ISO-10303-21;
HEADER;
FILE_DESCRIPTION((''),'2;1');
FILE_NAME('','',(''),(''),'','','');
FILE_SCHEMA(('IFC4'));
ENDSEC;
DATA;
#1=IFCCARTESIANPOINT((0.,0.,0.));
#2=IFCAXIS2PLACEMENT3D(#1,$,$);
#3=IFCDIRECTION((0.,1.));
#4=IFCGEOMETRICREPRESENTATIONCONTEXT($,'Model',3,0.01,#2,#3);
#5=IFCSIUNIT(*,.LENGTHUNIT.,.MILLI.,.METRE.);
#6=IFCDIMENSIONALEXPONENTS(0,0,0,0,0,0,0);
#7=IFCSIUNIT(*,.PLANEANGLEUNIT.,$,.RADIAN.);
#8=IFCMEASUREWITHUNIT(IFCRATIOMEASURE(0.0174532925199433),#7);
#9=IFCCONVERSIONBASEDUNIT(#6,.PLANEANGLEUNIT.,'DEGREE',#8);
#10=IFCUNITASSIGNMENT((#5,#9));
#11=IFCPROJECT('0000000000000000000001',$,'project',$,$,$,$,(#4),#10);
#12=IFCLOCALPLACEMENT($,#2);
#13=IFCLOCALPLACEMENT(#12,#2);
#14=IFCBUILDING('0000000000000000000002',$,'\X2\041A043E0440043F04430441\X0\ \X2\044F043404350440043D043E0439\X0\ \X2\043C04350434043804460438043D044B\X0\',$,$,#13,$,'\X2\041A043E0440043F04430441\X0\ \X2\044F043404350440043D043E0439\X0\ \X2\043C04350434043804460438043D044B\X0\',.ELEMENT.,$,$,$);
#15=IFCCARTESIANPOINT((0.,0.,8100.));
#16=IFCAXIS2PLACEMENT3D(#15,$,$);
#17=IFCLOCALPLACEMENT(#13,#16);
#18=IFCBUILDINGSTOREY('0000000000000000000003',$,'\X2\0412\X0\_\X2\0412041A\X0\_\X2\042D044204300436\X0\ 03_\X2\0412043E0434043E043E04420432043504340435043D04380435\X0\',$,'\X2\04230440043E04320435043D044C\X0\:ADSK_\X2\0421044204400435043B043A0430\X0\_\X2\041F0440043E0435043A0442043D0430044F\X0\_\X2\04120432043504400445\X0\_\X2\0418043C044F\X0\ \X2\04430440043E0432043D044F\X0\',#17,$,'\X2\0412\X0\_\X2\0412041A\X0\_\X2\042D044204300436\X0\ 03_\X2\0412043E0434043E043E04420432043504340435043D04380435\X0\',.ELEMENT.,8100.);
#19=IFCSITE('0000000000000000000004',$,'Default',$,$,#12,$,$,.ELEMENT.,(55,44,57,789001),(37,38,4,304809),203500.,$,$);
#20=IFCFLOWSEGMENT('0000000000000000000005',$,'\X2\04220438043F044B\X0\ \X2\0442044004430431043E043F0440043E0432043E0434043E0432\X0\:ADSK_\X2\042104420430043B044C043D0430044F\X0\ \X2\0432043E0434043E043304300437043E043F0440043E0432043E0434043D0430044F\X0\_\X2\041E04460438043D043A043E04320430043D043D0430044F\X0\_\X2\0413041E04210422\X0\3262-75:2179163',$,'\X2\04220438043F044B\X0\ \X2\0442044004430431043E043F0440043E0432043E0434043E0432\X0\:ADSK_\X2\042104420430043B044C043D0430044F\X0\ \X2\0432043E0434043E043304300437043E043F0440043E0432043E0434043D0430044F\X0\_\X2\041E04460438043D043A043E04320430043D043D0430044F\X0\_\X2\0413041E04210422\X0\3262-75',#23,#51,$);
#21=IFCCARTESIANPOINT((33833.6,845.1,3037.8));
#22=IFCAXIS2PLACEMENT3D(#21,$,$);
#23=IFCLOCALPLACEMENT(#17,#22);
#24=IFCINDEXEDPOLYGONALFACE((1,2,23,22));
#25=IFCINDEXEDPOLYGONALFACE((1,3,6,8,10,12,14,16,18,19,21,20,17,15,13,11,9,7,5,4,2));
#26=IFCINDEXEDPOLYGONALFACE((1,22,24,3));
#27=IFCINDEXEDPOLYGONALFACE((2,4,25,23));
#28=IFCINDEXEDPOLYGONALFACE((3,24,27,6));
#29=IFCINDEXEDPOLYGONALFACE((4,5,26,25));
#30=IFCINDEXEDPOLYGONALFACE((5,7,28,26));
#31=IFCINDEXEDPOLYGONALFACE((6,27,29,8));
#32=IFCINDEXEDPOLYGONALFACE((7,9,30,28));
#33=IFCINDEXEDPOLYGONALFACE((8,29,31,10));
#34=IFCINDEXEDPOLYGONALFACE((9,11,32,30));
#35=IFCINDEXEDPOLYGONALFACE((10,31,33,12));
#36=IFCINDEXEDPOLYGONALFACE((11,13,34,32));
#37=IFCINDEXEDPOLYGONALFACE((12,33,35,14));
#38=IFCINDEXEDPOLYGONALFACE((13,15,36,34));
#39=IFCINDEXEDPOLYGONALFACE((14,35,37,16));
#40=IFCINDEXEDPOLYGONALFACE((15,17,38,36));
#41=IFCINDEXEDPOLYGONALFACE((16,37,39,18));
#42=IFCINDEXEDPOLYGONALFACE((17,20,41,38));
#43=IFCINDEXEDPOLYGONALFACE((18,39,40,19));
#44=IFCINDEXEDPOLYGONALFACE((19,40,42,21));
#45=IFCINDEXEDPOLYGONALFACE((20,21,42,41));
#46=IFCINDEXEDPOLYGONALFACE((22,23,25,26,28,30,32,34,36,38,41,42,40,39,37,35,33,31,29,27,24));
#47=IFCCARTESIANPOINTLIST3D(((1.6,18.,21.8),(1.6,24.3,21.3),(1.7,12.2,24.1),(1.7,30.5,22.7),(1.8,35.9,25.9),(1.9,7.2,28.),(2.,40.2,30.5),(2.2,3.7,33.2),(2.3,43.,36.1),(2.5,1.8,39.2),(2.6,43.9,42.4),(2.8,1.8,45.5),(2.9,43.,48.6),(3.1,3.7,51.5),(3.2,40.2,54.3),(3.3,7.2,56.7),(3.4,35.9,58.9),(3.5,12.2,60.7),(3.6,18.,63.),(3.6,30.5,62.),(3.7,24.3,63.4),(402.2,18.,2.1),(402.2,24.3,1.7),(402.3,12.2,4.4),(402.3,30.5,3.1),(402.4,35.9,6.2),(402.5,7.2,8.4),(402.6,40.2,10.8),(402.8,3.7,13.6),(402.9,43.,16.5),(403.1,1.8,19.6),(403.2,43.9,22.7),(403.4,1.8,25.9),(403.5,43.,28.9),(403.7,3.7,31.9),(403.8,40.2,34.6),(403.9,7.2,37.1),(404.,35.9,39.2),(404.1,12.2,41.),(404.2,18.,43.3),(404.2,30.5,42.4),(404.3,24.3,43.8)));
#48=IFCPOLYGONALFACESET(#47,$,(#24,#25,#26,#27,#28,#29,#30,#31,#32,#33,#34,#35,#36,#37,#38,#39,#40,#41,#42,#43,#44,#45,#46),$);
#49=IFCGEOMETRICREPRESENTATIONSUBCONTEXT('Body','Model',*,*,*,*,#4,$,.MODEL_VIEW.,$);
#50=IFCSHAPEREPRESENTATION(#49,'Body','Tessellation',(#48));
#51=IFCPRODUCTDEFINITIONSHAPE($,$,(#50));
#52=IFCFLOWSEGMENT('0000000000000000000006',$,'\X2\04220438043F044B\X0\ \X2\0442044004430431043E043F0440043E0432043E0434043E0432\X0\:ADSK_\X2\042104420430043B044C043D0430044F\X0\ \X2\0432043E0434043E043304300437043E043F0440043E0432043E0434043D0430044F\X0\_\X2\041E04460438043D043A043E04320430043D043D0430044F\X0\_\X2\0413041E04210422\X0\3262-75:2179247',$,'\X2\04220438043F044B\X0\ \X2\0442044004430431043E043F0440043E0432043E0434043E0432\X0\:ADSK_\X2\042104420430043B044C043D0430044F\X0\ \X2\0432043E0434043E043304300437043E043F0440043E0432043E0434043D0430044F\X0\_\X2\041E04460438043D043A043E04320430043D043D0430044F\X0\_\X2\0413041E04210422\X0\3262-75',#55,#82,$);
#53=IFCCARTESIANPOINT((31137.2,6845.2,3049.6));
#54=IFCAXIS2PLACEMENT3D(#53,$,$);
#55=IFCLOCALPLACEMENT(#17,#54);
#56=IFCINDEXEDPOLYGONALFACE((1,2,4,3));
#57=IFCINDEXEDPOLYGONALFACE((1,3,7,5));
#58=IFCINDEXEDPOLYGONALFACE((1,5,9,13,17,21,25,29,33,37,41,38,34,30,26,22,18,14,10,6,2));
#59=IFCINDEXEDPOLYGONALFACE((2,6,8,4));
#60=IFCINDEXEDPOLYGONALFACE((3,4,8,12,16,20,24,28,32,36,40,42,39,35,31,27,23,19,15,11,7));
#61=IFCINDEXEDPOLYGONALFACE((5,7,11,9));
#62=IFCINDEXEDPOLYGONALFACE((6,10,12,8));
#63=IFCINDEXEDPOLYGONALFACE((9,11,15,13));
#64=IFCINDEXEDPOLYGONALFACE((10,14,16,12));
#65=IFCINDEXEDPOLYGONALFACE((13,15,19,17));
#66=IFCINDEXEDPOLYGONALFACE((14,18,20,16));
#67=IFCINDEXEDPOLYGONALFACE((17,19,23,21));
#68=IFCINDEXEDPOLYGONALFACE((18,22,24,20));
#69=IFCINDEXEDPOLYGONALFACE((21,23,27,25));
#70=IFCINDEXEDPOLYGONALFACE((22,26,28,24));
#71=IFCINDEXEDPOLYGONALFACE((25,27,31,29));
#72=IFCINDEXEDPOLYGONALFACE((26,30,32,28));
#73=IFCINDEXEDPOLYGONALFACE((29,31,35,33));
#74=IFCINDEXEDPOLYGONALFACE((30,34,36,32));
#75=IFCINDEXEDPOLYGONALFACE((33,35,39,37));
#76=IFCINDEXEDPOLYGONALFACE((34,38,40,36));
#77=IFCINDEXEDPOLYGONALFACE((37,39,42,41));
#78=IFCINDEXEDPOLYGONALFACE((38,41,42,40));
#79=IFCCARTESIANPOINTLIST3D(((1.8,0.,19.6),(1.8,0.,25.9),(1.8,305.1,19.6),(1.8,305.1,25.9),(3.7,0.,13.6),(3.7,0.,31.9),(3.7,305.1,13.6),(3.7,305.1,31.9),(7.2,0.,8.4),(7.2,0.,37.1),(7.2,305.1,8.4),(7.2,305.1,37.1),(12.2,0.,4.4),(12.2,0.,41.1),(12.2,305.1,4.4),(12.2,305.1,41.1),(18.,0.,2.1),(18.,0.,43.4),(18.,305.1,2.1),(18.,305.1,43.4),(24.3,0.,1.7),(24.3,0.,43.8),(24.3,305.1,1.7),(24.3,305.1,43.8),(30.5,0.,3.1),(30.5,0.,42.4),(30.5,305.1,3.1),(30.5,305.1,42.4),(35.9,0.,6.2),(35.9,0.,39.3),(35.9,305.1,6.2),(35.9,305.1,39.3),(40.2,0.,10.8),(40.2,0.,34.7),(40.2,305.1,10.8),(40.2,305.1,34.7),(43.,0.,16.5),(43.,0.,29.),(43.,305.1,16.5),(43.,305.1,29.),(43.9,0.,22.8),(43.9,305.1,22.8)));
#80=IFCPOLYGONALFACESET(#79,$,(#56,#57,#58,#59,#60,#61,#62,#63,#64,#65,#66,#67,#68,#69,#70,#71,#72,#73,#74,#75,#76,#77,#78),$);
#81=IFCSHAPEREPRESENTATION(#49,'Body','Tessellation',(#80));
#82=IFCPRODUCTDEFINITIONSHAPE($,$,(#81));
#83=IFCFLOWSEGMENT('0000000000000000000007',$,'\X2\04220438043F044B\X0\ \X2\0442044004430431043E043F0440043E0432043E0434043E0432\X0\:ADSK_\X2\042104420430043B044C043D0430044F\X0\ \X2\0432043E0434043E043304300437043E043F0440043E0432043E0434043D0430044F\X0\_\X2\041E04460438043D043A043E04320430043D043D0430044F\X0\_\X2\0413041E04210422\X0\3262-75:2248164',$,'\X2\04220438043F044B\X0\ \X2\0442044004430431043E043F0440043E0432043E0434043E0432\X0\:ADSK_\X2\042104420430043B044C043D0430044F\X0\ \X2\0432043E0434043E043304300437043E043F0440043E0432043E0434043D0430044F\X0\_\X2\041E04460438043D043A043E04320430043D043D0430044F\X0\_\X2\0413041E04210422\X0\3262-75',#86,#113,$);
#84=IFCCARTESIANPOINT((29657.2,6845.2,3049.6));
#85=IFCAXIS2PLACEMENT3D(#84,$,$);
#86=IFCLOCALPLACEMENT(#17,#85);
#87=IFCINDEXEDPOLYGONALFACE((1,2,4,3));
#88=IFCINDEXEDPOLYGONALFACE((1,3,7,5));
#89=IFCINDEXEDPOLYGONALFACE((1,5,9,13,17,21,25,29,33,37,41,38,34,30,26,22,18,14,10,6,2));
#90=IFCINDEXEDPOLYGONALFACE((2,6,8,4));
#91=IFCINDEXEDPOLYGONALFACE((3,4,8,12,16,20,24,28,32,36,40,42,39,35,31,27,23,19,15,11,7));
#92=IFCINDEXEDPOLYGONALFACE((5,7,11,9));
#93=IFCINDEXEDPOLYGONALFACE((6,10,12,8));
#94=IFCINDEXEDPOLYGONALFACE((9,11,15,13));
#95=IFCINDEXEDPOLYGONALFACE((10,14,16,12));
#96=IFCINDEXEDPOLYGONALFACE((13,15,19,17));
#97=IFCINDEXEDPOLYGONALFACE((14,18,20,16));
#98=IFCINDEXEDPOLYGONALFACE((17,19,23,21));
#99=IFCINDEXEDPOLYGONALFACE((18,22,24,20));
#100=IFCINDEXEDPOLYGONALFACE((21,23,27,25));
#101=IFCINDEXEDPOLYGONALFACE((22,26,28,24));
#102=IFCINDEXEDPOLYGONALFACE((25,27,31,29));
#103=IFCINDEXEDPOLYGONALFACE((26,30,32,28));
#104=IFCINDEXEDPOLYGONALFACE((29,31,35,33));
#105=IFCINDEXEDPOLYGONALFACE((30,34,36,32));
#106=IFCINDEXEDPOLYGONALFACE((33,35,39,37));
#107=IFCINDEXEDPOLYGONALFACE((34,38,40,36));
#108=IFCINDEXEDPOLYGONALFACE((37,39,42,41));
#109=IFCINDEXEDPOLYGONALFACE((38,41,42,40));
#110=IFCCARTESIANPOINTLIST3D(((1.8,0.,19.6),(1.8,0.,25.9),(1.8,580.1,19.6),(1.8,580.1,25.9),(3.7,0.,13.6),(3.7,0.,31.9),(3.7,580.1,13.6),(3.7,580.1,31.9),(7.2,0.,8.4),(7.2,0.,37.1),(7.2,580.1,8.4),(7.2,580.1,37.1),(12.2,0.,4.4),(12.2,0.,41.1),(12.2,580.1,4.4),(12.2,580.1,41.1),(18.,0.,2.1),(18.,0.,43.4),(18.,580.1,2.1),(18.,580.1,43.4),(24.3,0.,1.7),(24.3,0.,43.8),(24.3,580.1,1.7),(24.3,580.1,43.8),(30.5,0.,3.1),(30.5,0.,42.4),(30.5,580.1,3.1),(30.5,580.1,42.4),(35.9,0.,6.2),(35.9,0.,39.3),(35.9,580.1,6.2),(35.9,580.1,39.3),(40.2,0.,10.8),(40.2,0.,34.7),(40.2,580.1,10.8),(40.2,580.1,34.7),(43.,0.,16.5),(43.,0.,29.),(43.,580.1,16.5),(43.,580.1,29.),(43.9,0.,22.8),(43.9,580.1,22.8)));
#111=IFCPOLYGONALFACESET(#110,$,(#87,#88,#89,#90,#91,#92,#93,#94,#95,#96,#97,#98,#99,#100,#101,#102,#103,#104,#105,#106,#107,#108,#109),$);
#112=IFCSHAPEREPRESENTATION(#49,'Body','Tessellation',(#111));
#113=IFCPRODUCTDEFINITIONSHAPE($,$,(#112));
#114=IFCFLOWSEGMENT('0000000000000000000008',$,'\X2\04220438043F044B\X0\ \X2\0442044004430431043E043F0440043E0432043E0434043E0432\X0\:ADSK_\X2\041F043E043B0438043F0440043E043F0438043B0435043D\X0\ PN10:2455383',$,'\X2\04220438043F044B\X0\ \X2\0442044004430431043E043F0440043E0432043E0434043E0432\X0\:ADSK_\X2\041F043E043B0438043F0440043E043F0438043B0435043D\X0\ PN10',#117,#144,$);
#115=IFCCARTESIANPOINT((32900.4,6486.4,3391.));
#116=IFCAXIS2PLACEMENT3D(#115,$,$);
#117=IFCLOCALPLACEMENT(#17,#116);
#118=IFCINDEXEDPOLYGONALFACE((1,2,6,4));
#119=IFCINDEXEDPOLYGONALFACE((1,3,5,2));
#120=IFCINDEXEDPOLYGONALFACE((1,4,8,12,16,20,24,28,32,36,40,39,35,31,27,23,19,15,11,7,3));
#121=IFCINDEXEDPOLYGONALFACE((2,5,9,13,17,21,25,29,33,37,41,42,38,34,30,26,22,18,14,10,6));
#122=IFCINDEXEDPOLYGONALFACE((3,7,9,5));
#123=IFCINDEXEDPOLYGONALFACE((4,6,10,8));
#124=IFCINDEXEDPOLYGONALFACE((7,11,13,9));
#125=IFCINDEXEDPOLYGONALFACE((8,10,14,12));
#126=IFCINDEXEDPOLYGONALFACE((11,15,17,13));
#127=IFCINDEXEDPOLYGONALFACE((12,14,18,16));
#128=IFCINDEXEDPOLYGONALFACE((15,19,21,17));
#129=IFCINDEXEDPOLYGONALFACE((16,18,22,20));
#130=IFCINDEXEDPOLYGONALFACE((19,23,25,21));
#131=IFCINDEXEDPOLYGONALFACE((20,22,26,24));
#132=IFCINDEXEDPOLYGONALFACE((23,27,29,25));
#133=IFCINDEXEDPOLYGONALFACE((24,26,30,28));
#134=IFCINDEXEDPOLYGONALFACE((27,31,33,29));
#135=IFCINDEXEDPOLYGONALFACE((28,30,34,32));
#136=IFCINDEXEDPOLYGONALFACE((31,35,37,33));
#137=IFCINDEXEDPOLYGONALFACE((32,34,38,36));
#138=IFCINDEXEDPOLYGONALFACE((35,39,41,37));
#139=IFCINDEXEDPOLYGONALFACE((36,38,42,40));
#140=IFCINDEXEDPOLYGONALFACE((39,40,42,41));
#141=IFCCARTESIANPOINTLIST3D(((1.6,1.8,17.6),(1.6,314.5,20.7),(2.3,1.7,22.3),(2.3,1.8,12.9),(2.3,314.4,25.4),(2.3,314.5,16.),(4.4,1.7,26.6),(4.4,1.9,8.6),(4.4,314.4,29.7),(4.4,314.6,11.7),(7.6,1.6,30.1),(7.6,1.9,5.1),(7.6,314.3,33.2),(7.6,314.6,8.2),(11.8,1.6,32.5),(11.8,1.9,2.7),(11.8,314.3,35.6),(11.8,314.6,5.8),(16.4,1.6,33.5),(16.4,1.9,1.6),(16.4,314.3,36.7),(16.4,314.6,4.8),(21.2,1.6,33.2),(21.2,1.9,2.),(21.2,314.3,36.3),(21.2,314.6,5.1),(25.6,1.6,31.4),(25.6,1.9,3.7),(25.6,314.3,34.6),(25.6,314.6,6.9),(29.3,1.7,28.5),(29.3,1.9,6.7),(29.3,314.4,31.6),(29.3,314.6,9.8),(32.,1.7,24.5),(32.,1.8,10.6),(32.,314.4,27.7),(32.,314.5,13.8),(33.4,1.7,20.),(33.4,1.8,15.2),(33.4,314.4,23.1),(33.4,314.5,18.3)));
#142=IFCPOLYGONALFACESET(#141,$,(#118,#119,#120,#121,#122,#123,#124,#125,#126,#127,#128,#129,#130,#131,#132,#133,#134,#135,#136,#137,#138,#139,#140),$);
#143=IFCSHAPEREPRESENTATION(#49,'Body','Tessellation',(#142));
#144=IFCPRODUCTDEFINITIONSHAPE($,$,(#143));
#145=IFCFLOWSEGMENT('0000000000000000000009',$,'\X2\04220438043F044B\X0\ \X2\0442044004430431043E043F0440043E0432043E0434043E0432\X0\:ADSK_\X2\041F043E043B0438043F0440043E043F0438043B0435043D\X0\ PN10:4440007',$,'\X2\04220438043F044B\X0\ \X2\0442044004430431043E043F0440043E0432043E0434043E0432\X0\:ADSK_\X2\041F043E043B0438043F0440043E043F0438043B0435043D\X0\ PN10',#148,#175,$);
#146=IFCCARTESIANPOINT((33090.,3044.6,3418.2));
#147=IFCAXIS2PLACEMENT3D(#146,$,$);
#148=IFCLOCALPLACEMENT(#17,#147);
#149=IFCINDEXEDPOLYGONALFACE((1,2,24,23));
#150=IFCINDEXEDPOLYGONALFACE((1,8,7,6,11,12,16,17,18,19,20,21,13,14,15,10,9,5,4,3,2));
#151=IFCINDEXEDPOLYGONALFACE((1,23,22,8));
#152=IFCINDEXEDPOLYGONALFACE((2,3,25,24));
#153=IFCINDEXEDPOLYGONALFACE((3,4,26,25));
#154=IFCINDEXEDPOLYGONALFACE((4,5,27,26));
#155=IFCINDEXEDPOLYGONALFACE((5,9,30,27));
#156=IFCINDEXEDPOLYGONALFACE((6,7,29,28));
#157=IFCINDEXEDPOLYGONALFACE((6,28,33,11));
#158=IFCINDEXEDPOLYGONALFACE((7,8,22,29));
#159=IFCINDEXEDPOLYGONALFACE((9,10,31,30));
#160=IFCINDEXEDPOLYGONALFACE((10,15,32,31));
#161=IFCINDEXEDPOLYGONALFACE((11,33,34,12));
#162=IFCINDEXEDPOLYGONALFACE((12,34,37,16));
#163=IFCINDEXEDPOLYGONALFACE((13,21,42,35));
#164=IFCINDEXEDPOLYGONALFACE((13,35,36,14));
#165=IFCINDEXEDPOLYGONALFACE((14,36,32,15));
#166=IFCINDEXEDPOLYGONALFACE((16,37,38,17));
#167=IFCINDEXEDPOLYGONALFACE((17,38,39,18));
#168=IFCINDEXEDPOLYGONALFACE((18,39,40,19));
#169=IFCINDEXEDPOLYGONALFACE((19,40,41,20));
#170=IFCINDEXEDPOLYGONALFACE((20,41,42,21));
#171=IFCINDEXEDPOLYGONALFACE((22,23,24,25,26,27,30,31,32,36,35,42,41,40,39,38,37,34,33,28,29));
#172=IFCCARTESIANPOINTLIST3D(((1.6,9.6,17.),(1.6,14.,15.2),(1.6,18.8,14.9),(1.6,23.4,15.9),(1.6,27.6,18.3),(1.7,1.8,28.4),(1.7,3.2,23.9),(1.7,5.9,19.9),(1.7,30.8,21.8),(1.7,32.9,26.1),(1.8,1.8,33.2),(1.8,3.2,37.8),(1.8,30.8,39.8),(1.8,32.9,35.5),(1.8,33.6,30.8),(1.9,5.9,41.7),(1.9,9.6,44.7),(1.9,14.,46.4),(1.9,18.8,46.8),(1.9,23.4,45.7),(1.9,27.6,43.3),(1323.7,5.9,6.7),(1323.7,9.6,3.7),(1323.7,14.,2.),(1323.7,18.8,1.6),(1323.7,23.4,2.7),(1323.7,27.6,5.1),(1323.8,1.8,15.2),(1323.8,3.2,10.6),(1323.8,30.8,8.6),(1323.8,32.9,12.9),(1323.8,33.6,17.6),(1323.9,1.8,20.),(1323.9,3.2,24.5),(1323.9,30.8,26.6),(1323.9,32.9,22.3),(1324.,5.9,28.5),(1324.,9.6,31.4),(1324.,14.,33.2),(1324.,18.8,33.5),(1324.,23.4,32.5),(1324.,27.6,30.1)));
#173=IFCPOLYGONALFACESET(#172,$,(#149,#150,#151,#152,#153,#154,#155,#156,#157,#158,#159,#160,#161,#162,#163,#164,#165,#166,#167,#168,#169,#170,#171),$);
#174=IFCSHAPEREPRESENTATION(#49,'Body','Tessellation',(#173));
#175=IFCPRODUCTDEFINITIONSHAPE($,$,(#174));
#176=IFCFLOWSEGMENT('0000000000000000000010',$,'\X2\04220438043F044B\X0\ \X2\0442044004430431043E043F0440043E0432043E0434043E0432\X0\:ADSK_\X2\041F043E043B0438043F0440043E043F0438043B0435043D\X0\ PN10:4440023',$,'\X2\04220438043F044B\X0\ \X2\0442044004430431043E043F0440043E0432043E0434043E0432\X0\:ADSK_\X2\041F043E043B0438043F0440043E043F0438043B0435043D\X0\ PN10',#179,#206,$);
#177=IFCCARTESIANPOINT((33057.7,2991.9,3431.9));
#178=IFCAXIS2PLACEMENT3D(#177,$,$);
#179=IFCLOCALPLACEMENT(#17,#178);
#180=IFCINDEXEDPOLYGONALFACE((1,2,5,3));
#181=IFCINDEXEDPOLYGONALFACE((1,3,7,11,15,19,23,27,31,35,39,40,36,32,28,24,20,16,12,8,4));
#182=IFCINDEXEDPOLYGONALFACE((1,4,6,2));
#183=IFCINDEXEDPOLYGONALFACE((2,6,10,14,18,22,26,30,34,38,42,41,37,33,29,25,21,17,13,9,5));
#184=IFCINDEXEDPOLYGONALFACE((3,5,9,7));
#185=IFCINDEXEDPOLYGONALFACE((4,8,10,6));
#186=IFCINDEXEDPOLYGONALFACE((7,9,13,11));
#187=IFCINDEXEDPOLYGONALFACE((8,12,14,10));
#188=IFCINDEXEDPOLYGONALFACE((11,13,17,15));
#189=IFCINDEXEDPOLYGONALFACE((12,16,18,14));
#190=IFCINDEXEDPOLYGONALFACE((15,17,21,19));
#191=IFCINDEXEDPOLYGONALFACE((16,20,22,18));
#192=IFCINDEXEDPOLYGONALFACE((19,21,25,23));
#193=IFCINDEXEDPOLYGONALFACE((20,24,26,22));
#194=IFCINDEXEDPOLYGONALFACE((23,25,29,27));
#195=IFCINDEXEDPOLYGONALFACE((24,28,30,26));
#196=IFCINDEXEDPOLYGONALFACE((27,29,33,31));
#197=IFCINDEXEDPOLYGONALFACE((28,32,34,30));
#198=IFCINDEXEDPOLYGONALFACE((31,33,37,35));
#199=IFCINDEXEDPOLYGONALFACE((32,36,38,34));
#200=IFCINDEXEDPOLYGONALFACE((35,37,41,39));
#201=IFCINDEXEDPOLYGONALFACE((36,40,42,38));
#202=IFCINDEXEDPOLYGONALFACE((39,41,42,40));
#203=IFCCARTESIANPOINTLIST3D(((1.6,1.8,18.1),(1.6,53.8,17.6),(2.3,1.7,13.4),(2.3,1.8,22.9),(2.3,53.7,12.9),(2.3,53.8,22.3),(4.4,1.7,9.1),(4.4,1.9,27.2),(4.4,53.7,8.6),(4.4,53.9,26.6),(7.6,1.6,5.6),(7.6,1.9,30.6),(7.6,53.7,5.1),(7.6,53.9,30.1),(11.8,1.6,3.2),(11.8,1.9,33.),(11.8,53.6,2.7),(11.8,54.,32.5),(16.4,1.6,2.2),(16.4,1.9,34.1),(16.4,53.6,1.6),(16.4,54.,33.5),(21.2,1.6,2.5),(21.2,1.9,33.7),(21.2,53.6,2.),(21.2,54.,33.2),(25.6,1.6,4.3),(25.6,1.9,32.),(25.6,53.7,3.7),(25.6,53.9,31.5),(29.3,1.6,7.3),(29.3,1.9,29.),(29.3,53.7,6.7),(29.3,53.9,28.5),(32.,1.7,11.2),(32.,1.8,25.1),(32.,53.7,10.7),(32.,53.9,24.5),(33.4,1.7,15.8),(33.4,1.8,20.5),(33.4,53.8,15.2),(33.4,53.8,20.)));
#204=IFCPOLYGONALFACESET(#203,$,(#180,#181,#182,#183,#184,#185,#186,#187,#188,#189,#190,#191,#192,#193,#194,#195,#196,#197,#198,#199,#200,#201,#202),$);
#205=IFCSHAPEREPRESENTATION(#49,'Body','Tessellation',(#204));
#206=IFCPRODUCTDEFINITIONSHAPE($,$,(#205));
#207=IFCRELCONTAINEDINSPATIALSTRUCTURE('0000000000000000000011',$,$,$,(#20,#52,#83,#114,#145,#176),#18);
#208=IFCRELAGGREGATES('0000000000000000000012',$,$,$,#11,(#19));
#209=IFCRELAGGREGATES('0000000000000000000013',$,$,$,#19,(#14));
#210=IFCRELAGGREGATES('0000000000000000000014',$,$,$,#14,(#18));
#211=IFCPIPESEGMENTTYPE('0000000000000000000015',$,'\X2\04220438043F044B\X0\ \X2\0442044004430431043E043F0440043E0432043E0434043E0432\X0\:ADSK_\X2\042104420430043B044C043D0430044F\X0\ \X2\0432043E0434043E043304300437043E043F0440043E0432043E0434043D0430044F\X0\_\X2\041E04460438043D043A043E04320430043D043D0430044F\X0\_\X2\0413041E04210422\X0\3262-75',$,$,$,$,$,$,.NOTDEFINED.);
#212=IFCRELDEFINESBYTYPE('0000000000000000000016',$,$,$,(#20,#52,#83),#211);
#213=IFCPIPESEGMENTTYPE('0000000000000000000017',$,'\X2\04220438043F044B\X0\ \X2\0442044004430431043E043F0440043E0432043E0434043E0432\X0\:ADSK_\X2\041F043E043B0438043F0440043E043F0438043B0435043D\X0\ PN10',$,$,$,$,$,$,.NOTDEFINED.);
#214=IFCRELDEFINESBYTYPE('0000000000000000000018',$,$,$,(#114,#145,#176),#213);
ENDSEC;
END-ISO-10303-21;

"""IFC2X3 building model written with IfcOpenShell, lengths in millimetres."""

from ifc_helpers import new_model, entity, si_unit, converted_unit, direction, frame, origin, origin_2d_with_axis, place, context, subcontext, project, spatial, circle, extrude, type_object, element, save


model = new_model("IFC2X3")

# Units and contexts
model_context = context("Model", 3, precision=0.01, world=origin(), true_north=direction((0.0, 1.0)))
body_context = subcontext(model_context, "Body", "Model", "MODEL_VIEW")
ifc_project = project(units=[si_unit("LENGTHUNIT", "METRE", prefix="MILLI"), converted_unit("PLANEANGLEUNIT", "DEGREE", entity("IfcRatioMeasure", 0.0174532925199433), si_unit("PLANEANGLEUNIT", "RADIAN"), dimensions=[0, 0, 0, 0, 0, 0, 0])], contexts=[model_context])

# Site, building, storey
site_placement = place(None, origin())
site = spatial("IfcSite", under=ifc_project, at=site_placement, Name="Default", CompositionType="ELEMENT", RefLatitude=(55, 44, 57, 789001), RefLongitude=(37, 38, 4, 304809), RefElevation=203500.0)
building_placement = place(site_placement, origin())
building = spatial("IfcBuilding", under=site, at=building_placement, Name="Корпус ядерной медицины", LongName="Корпус ядерной медицины", CompositionType="ELEMENT")
storey_placement = place(building_placement, frame((0.0, 0.0, 8100.0)))
storey = spatial("IfcBuildingStorey", under=building, at=storey_placement, Name="В_ВК_Этаж 03_Водоотведение", ObjectType="Уровень:ADSK_Стрелка_Проектная_Вверх_Имя уровня", LongName="В_ВК_Этаж 03_Водоотведение", CompositionType="ELEMENT", Elevation=8100.0)

# Flow segments
pipe_segment_type_1 = type_object("IfcPipeSegmentType", Name="Типы трубопроводов:ADSK_Стальная водогазопроводная_Оцинкованная_ГОСТ3262-75", PredefinedType="NOTDEFINED")
flow_segment_1_placement = place(storey_placement, frame((33833.6, 845.1, 3037.8)))
element("IfcFlowSegment", 1, at=flow_segment_1_placement, inside=storey, type_object=pipe_segment_type_1, Name="Типы трубопроводов:ADSK_Стальная водогазопроводная_Оцинкованная_ГОСТ3262-75:2179163", ObjectType="Типы трубопроводов:ADSK_Стальная водогазопроводная_Оцинкованная_ГОСТ3262-75", context=body_context, shape_type="SweptSolid", body=[
    extrude(circle(Radius=21.1, at=origin_2d_with_axis()), frame((403.2, 22.8, 22.7), z_axis=(-0.998799, 0.0, 0.048994), x_axis=(0.0, 1.0, 0.0)), (0.0, 0.0, 1.0), 401.1),
])
flow_segment_2_placement = place(storey_placement, frame((31137.2, 6845.2, 3049.6)))
element("IfcFlowSegment", 2, at=flow_segment_2_placement, inside=storey, type_object=pipe_segment_type_1, Name="Типы трубопроводов:ADSK_Стальная водогазопроводная_Оцинкованная_ГОСТ3262-75:2179247", ObjectType="Типы трубопроводов:ADSK_Стальная водогазопроводная_Оцинкованная_ГОСТ3262-75", context=body_context, shape_type="SweptSolid", body=[
    extrude(circle(Radius=21.1, at=origin_2d_with_axis()), frame((22.8, 0.0, 22.8), z_axis=(0.0, 1.0, 0.0), x_axis=(1.0, 0.0, 0.0)), (0.0, 0.0, 1.0), 305.1),
])
flow_segment_3_placement = place(storey_placement, frame((29657.2, 6845.2, 3049.6)))
element("IfcFlowSegment", 3, at=flow_segment_3_placement, inside=storey, type_object=pipe_segment_type_1, Name="Типы трубопроводов:ADSK_Стальная водогазопроводная_Оцинкованная_ГОСТ3262-75:2248164", ObjectType="Типы трубопроводов:ADSK_Стальная водогазопроводная_Оцинкованная_ГОСТ3262-75", context=body_context, shape_type="SweptSolid", body=[
    extrude(circle(Radius=21.1, at=origin_2d_with_axis()), frame((22.8, 0.0, 22.8), z_axis=(0.0, 1.0, 0.0), x_axis=(1.0, 0.0, 0.0)), (0.0, 0.0, 1.0), 580.1),
])
pipe_segment_type_2 = type_object("IfcPipeSegmentType", Name="Типы трубопроводов:ADSK_Полипропилен PN10", PredefinedType="NOTDEFINED")
flow_segment_4_placement = place(storey_placement, frame((32900.4, 6486.4, 3391.0)))
element("IfcFlowSegment", 4, at=flow_segment_4_placement, inside=storey, type_object=pipe_segment_type_2, Name="Типы трубопроводов:ADSK_Полипропилен PN10:2455383", ObjectType="Типы трубопроводов:ADSK_Полипропилен PN10", context=body_context, shape_type="SweptSolid", body=[
    extrude(circle(Radius=16.0, at=origin_2d_with_axis()), frame((17.6, 1.8, 17.6), z_axis=(0.0, 0.99995, 0.01), x_axis=(-1.0, 0.0, 0.0)), (0.0, 0.0, 1.0), 312.7),
])
flow_segment_5_placement = place(storey_placement, frame((33090.0, 3044.6, 3418.2)))
element("IfcFlowSegment", 5, at=flow_segment_5_placement, inside=storey, type_object=pipe_segment_type_2, Name="Типы трубопроводов:ADSK_Полипропилен PN10:4440007", ObjectType="Типы трубопроводов:ADSK_Полипропилен PN10", context=body_context, shape_type="SweptSolid", body=[
    extrude(circle(Radius=16.0, at=origin_2d_with_axis()), frame((1323.8, 17.6, 17.6), z_axis=(-0.99995, 0.0, 0.01), x_axis=(0.0, 1.0, 0.0)), (0.0, 0.0, 1.0), 1322.2),
])
flow_segment_6_placement = place(storey_placement, frame((33057.7, 2991.9, 3431.9)))
element("IfcFlowSegment", 6, at=flow_segment_6_placement, inside=storey, type_object=pipe_segment_type_2, Name="Типы трубопроводов:ADSK_Полипропилен PN10:4440023", ObjectType="Типы трубопроводов:ADSK_Полипропилен PN10", context=body_context, shape_type="SweptSolid", body=[
    extrude(circle(Radius=16.0, at=origin_2d_with_axis()), frame((17.6, 1.8, 18.1), z_axis=(0.0, 0.999945, -0.01048), x_axis=(-1.0, 0.0, 0.0)), (0.0, 0.0, 1.0), 52.0),
])

save(model, "model.ifc")
